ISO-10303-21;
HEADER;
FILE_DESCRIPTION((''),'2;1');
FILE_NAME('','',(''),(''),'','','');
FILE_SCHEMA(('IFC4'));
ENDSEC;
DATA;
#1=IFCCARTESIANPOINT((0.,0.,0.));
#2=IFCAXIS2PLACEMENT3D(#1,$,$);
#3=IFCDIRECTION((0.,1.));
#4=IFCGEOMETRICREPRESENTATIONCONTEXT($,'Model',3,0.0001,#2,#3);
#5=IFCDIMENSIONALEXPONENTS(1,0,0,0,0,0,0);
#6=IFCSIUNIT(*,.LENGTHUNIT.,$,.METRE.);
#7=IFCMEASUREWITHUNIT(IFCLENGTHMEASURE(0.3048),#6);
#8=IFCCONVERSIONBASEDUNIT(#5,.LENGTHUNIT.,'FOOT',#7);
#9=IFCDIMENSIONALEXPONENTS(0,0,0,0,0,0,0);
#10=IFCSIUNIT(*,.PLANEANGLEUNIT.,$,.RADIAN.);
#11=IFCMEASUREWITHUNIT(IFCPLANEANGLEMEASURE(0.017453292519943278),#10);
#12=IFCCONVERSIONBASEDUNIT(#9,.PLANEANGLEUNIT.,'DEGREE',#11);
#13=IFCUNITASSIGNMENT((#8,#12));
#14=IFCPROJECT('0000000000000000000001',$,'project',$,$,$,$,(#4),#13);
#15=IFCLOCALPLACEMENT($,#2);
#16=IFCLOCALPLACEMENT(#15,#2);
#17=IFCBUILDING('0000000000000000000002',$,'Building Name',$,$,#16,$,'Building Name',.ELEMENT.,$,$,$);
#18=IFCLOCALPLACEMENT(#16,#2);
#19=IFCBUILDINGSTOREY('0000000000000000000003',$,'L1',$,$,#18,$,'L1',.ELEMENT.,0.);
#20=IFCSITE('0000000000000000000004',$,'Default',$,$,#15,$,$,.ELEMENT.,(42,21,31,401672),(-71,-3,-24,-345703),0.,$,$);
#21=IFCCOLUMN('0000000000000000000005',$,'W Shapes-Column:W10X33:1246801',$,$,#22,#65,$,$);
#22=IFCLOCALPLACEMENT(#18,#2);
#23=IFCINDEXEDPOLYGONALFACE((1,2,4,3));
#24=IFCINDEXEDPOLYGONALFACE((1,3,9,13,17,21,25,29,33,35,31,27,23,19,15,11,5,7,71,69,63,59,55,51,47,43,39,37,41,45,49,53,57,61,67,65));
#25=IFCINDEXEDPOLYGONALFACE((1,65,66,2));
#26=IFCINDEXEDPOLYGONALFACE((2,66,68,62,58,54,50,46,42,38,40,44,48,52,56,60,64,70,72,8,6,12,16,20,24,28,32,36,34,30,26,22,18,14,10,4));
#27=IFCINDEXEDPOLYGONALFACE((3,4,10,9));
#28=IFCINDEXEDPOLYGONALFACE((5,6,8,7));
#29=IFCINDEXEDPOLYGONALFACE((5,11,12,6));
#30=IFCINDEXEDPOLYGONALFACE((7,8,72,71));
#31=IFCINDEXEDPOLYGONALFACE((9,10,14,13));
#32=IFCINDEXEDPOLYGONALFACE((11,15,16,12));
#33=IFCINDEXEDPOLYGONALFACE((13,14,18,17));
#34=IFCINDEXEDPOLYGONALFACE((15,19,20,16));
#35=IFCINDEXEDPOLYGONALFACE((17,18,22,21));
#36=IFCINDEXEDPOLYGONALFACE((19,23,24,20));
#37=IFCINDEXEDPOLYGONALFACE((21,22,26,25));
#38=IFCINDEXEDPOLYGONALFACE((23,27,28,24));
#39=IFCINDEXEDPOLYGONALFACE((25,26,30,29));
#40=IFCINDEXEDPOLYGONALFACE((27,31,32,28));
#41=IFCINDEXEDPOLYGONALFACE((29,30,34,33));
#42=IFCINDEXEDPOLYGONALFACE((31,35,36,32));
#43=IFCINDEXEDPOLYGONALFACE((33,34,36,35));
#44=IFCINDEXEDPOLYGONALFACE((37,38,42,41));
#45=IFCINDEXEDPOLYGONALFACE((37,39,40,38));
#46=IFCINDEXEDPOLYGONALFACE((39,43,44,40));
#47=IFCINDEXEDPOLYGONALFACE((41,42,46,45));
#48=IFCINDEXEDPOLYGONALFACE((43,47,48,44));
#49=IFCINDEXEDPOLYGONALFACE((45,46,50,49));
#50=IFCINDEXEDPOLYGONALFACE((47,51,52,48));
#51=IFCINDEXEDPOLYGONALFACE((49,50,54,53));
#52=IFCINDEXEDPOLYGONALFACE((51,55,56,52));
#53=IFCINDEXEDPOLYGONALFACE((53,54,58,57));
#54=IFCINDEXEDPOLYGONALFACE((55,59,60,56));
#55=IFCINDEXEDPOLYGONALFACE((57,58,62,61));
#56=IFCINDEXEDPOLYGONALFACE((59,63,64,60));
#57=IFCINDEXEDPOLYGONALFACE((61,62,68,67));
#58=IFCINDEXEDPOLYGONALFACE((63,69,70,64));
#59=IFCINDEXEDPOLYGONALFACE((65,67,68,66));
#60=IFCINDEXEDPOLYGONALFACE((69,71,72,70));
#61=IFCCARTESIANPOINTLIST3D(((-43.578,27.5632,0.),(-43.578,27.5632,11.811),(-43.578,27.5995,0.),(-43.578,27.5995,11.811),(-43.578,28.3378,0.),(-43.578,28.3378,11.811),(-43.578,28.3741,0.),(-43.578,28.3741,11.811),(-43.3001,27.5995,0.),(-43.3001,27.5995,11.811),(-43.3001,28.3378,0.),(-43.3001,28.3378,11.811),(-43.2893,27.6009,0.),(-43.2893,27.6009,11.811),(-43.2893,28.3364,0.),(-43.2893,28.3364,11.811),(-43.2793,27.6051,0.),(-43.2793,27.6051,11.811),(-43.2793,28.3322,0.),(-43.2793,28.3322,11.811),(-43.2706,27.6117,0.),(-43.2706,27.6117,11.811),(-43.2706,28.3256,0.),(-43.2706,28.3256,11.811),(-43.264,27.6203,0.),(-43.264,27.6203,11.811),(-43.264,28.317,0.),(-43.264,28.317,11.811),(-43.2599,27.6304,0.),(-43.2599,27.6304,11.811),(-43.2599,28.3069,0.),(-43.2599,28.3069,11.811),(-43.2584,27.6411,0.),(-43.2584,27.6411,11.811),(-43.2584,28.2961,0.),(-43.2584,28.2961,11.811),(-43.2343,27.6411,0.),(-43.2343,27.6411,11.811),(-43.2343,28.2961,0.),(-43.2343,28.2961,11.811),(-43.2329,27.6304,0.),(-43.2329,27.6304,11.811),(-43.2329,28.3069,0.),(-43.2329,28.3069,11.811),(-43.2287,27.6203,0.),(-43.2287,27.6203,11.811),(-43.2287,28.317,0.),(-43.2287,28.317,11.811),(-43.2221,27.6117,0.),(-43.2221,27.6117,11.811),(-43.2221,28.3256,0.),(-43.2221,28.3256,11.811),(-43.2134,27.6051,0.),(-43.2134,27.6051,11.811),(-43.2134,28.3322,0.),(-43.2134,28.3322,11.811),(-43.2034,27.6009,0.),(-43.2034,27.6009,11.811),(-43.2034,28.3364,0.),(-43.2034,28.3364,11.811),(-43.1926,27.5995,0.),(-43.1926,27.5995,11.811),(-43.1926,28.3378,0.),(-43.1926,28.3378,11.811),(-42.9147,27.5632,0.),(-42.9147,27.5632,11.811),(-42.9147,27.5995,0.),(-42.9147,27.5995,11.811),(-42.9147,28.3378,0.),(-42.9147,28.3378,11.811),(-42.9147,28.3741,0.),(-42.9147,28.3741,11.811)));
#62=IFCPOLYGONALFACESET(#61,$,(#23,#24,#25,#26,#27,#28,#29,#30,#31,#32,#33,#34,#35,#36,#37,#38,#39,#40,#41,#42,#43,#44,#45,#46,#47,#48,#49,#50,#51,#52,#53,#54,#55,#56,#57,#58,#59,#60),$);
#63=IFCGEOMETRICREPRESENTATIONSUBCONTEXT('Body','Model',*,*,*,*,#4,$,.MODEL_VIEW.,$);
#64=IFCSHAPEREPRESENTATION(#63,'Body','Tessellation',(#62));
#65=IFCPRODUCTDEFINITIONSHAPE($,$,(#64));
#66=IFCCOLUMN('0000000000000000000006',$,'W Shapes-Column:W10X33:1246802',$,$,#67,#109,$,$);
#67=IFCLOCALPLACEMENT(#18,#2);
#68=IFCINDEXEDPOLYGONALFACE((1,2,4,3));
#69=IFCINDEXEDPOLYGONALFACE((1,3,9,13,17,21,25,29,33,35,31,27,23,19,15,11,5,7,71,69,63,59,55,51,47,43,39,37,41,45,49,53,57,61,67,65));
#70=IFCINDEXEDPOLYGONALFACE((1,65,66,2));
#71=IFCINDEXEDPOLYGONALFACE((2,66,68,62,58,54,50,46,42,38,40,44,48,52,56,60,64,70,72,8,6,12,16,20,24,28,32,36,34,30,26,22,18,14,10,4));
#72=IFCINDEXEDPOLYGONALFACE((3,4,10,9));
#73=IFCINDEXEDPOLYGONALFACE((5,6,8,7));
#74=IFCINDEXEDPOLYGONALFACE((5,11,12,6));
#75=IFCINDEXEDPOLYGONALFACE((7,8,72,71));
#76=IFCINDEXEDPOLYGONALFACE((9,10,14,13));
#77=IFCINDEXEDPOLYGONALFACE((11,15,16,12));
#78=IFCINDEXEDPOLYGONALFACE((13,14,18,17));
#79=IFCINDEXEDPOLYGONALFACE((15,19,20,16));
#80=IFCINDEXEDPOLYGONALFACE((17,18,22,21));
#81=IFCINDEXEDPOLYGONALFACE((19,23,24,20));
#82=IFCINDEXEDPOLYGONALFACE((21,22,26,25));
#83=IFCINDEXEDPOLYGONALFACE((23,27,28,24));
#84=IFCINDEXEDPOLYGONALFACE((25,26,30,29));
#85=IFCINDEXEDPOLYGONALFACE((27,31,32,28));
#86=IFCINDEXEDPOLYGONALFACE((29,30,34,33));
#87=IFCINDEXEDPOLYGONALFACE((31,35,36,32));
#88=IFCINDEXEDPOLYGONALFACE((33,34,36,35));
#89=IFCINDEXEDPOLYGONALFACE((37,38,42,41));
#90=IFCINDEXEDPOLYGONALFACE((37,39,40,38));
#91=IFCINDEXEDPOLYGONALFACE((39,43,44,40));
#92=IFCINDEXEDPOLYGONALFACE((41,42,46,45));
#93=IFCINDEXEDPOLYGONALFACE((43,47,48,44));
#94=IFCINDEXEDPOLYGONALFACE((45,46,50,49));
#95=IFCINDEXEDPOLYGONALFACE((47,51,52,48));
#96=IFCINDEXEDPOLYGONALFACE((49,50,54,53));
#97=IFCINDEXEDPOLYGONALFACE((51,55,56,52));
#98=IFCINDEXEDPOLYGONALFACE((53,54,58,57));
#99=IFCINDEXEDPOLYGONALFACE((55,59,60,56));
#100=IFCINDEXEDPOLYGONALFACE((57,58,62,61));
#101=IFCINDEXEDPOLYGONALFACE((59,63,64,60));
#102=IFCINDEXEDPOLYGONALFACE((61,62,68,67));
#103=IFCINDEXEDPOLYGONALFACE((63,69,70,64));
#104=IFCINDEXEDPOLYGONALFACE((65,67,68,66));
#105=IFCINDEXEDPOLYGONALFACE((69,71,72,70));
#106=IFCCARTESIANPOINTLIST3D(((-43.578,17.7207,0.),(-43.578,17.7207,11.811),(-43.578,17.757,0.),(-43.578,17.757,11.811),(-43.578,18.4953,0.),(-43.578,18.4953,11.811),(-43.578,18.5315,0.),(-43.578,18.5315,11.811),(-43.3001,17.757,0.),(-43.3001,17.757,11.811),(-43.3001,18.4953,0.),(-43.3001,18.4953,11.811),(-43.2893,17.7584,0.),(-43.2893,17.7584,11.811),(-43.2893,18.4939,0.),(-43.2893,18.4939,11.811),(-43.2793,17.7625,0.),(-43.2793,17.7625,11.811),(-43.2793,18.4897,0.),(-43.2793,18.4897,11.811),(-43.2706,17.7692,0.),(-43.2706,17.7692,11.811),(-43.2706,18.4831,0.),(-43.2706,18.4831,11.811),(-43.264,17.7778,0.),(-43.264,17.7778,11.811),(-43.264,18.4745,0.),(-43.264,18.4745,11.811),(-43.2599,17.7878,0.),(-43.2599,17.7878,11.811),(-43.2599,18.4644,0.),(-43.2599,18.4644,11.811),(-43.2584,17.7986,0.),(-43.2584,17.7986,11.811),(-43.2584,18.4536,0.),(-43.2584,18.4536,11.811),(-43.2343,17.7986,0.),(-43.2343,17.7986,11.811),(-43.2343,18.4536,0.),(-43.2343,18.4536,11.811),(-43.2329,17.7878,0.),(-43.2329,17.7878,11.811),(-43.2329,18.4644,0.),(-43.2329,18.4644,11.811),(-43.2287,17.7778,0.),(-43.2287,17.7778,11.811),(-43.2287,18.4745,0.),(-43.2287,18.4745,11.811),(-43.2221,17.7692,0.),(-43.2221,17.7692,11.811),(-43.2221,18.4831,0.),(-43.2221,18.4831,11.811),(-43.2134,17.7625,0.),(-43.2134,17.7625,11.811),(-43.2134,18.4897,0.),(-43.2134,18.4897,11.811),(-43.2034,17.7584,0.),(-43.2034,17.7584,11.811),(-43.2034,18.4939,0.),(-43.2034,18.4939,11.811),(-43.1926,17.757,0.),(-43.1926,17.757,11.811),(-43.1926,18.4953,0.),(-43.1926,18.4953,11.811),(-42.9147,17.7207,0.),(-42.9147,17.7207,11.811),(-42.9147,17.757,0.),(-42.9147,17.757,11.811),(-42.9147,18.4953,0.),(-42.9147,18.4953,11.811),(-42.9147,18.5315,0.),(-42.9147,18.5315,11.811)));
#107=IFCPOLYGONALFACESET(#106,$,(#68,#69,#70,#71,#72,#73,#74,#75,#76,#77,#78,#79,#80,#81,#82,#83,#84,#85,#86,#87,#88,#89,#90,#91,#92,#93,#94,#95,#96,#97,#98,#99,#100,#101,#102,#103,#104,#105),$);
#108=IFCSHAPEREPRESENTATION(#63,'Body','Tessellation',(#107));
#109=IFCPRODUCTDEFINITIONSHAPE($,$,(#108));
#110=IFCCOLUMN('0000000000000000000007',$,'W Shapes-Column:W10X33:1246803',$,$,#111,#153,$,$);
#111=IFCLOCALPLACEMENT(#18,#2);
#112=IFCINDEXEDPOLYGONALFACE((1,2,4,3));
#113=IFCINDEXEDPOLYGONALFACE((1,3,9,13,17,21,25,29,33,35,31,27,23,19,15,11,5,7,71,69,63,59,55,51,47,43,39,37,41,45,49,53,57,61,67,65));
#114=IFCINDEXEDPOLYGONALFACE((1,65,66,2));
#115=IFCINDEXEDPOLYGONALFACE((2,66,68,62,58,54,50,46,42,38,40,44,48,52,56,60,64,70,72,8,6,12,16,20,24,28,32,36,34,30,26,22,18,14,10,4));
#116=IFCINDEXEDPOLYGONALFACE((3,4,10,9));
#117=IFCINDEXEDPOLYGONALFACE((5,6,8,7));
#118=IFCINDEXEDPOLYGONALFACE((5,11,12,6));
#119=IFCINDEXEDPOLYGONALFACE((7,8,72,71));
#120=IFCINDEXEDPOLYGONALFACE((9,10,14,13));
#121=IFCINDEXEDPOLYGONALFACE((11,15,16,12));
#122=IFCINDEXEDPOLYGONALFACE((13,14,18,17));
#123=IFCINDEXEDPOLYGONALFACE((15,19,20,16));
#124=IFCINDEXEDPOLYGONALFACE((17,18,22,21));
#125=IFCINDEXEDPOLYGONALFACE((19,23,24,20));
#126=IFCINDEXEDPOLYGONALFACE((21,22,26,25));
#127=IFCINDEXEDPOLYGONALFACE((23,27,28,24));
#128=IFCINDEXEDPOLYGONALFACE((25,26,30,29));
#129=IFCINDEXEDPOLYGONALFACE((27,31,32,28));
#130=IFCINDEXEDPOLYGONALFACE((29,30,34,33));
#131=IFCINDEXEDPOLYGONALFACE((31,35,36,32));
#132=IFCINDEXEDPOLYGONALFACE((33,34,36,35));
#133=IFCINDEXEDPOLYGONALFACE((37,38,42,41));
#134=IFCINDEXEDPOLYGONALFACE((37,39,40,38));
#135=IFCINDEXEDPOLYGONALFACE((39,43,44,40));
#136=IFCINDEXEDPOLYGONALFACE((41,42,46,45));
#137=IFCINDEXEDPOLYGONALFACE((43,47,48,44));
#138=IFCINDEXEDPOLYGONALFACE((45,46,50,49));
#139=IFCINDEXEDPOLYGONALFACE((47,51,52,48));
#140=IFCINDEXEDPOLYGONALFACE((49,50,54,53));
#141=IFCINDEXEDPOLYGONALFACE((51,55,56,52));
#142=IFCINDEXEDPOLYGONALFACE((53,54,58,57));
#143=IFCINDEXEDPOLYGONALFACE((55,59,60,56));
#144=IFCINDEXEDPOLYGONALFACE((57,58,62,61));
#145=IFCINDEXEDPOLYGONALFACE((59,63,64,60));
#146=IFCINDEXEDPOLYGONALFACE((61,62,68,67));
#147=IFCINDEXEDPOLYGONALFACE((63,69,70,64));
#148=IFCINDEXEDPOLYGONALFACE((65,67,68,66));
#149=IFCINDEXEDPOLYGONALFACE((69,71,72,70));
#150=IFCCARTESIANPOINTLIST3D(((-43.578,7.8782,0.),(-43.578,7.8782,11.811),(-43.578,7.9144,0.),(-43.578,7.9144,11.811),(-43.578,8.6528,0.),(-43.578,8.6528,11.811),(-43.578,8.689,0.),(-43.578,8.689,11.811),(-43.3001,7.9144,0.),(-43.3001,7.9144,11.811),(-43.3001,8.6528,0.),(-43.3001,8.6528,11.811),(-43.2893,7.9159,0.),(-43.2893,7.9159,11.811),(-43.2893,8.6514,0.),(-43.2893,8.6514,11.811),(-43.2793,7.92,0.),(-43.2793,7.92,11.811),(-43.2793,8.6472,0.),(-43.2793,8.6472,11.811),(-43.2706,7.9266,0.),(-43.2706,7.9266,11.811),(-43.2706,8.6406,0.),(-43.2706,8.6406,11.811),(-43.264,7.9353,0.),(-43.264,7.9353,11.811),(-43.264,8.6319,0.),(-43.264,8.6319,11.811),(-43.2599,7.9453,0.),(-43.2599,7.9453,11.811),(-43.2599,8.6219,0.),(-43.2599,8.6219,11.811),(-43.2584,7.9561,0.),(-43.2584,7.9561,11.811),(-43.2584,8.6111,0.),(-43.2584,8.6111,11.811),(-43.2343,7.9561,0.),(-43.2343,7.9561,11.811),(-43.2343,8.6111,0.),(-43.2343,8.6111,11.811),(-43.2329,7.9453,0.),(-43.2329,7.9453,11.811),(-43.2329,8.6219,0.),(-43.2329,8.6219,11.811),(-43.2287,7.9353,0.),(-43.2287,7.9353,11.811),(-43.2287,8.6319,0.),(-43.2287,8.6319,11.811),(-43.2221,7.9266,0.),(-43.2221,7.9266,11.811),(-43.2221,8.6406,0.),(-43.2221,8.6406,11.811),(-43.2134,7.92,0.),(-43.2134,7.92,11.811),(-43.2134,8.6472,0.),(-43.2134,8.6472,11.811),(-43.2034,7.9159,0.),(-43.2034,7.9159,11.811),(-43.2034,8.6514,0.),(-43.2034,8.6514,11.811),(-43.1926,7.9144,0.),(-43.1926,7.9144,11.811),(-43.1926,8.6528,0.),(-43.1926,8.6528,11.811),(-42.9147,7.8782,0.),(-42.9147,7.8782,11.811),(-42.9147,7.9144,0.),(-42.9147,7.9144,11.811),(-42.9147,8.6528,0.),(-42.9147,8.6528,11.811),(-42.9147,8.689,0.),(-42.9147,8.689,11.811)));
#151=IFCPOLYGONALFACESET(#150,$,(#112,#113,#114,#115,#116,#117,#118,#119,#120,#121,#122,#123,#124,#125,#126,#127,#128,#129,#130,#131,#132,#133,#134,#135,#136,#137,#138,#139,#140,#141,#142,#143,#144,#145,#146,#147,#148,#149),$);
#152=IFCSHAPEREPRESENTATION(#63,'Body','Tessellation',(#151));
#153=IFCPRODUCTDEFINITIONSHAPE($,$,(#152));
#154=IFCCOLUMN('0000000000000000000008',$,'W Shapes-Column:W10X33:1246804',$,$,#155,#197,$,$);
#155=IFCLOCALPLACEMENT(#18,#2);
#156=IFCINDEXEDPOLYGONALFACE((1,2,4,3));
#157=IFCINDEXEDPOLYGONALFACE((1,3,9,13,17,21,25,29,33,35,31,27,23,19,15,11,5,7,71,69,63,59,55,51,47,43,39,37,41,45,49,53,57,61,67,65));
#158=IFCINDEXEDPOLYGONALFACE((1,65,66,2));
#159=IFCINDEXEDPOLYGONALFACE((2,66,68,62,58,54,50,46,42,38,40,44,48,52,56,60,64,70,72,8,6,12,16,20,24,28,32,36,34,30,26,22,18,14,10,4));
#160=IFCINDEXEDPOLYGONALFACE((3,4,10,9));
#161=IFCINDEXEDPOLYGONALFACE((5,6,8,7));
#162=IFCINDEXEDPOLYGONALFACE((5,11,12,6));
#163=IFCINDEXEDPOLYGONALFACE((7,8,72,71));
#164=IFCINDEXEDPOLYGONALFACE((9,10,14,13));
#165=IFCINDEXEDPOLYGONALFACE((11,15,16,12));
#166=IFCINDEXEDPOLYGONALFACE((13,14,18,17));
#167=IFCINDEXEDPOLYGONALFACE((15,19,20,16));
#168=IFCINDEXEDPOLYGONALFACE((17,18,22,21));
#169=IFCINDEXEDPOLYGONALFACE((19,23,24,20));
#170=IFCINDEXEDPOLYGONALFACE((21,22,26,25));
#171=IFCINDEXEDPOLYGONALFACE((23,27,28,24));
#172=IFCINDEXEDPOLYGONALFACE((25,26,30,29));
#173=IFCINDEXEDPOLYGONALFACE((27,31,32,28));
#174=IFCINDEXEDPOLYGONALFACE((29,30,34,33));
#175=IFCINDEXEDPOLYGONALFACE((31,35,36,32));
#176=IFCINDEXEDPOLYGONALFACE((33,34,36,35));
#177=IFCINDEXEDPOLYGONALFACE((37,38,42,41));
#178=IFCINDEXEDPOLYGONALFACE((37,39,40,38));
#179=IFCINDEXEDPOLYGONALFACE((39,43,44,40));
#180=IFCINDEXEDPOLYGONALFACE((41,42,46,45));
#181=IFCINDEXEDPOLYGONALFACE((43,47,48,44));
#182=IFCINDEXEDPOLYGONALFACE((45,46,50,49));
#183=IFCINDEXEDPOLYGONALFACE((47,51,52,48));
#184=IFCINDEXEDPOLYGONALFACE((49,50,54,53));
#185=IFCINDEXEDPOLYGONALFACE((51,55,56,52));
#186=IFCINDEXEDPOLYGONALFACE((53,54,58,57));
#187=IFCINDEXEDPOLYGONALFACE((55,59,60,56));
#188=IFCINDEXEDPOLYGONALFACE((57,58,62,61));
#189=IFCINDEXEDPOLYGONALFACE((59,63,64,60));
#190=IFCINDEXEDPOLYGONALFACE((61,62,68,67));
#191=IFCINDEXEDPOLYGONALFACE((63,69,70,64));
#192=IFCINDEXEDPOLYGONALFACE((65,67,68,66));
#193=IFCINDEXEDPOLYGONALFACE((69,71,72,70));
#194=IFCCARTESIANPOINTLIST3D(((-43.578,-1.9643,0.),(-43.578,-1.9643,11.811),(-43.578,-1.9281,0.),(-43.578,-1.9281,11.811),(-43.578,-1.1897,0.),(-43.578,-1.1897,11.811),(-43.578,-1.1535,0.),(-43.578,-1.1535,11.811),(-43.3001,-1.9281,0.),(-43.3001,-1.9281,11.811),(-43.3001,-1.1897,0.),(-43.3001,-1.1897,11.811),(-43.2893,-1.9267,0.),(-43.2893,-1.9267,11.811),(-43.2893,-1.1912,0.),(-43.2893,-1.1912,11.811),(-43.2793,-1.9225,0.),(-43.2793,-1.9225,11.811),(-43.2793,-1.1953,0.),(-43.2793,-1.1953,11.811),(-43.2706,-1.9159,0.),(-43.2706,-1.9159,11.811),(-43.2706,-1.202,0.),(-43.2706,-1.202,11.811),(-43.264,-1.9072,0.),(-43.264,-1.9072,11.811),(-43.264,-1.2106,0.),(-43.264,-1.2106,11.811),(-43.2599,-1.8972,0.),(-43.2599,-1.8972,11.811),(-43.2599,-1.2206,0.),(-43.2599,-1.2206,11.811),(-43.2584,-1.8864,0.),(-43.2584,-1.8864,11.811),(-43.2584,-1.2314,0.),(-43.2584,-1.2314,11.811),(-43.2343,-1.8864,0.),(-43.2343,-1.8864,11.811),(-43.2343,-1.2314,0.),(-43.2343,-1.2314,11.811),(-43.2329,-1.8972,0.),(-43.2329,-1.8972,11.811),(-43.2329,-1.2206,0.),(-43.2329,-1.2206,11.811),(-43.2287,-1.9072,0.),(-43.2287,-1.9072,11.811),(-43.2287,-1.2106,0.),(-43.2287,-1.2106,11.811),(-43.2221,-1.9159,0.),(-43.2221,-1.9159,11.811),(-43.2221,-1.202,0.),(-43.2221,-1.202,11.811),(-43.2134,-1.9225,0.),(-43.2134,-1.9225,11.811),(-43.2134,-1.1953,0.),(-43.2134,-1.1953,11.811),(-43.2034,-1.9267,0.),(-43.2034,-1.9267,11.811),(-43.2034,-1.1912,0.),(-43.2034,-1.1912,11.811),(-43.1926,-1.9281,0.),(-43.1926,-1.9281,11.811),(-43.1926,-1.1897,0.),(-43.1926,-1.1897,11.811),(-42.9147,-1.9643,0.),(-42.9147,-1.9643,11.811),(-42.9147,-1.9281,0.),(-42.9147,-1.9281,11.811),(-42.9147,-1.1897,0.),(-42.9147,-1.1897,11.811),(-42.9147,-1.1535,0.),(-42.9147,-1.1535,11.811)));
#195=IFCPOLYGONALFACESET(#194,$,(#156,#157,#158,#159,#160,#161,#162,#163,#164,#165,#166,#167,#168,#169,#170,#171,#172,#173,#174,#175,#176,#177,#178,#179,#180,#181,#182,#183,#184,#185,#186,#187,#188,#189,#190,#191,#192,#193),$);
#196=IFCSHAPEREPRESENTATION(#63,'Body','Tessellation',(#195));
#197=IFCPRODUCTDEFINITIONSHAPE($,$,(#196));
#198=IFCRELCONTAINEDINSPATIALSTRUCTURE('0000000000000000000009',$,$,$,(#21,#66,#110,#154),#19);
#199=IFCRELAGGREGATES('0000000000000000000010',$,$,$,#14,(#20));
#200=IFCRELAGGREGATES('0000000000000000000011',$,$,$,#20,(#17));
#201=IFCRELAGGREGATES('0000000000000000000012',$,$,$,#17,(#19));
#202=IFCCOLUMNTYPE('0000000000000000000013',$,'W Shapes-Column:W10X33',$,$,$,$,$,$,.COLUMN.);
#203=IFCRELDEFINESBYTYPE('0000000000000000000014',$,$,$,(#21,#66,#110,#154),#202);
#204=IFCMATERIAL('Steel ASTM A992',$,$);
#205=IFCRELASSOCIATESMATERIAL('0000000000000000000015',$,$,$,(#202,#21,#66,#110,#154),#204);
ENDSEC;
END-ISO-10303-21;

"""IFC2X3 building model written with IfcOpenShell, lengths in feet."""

from ifc_helpers import new_model, entity, si_unit, converted_unit, direction, frame, frame_2d, origin, place, context, subcontext, project, spatial, i_section, extrude, source, transform, mapped, material, type_object, type_shapes, element, save


model = new_model("IFC2X3")

# Units and contexts
model_context = context("Model", 3, precision=0.0001, world=origin(), true_north=direction((0.0, 1.0)))
body_context = subcontext(model_context, "Body", "Model", "MODEL_VIEW")
ifc_project = project(units=[converted_unit("LENGTHUNIT", "FOOT", entity("IfcLengthMeasure", 0.3048), si_unit("LENGTHUNIT", "METRE"), dimensions=[1, 0, 0, 0, 0, 0, 0]), converted_unit("PLANEANGLEUNIT", "DEGREE", entity("IfcPlaneAngleMeasure", 0.017453292519943278), si_unit("PLANEANGLEUNIT", "RADIAN"), dimensions=[0, 0, 0, 0, 0, 0, 0])], contexts=[model_context])

# Site, building, storey
site_placement = place(None, origin())
site = spatial("IfcSite", under=ifc_project, at=site_placement, Name="Default", CompositionType="ELEMENT", RefLatitude=(42, 21, 31, 401672), RefLongitude=(-71, -3, -24, -345703), RefElevation=0.0)
building_placement = place(site_placement, origin())
building = spatial("IfcBuilding", under=site, at=building_placement, Name="Building Name", LongName="Building Name", CompositionType="ELEMENT")
storey_placement = place(building_placement, origin())
storey = spatial("IfcBuildingStorey", under=building, at=storey_placement, Name="L1", LongName="L1", CompositionType="ELEMENT", Elevation=0.0)

# Columns
ifc_material = material(Name="Steel ASTM A992")
column_type = type_object("IfcColumnType", Name="W Shapes-Column:W10X33", PredefinedType="COLUMN", material=ifc_material)
shared_shape = source(origin(), body_context, "Body", "SweptSolid", [
    extrude(i_section(OverallWidth=0.6633, OverallDepth=0.8108, WebThickness=0.0242, FlangeThickness=0.0362, FilletRadius=0.0417, at=frame_2d((0.0, 0.0), x_axis=(1.0, 0.0))), frame((0.0, 0.0, 0.0), z_axis=(0.0, 0.0, 1.0), x_axis=(-1.0, 0.0, 0.0)), (0.0, 0.0, 1.0), 11.811),
])
type_shapes(column_type, [shared_shape])
for number, where, name in (
    (1, (-43.2464, 27.9686, 0.0), "W Shapes-Column:W10X33:1246801"),
    (2, (-43.2464, 18.1261, 0.0), "W Shapes-Column:W10X33:1246802"),
    (3, (-43.2464, 8.2836, 0.0), "W Shapes-Column:W10X33:1246803"),
    (4, (-43.2464, -1.5589, 0.0), "W Shapes-Column:W10X33:1246804"),
):
    element("IfcColumn", number, at=place(storey_placement, frame(where)), inside=storey, type_object=column_type, material=ifc_material, Name=name, context=body_context, shape_type="MappedRepresentation", body=[
        mapped(shared_shape, transform((0.0, 0.0, 0.0), scale=1.0)),
    ])

save(model, "model.ifc")
